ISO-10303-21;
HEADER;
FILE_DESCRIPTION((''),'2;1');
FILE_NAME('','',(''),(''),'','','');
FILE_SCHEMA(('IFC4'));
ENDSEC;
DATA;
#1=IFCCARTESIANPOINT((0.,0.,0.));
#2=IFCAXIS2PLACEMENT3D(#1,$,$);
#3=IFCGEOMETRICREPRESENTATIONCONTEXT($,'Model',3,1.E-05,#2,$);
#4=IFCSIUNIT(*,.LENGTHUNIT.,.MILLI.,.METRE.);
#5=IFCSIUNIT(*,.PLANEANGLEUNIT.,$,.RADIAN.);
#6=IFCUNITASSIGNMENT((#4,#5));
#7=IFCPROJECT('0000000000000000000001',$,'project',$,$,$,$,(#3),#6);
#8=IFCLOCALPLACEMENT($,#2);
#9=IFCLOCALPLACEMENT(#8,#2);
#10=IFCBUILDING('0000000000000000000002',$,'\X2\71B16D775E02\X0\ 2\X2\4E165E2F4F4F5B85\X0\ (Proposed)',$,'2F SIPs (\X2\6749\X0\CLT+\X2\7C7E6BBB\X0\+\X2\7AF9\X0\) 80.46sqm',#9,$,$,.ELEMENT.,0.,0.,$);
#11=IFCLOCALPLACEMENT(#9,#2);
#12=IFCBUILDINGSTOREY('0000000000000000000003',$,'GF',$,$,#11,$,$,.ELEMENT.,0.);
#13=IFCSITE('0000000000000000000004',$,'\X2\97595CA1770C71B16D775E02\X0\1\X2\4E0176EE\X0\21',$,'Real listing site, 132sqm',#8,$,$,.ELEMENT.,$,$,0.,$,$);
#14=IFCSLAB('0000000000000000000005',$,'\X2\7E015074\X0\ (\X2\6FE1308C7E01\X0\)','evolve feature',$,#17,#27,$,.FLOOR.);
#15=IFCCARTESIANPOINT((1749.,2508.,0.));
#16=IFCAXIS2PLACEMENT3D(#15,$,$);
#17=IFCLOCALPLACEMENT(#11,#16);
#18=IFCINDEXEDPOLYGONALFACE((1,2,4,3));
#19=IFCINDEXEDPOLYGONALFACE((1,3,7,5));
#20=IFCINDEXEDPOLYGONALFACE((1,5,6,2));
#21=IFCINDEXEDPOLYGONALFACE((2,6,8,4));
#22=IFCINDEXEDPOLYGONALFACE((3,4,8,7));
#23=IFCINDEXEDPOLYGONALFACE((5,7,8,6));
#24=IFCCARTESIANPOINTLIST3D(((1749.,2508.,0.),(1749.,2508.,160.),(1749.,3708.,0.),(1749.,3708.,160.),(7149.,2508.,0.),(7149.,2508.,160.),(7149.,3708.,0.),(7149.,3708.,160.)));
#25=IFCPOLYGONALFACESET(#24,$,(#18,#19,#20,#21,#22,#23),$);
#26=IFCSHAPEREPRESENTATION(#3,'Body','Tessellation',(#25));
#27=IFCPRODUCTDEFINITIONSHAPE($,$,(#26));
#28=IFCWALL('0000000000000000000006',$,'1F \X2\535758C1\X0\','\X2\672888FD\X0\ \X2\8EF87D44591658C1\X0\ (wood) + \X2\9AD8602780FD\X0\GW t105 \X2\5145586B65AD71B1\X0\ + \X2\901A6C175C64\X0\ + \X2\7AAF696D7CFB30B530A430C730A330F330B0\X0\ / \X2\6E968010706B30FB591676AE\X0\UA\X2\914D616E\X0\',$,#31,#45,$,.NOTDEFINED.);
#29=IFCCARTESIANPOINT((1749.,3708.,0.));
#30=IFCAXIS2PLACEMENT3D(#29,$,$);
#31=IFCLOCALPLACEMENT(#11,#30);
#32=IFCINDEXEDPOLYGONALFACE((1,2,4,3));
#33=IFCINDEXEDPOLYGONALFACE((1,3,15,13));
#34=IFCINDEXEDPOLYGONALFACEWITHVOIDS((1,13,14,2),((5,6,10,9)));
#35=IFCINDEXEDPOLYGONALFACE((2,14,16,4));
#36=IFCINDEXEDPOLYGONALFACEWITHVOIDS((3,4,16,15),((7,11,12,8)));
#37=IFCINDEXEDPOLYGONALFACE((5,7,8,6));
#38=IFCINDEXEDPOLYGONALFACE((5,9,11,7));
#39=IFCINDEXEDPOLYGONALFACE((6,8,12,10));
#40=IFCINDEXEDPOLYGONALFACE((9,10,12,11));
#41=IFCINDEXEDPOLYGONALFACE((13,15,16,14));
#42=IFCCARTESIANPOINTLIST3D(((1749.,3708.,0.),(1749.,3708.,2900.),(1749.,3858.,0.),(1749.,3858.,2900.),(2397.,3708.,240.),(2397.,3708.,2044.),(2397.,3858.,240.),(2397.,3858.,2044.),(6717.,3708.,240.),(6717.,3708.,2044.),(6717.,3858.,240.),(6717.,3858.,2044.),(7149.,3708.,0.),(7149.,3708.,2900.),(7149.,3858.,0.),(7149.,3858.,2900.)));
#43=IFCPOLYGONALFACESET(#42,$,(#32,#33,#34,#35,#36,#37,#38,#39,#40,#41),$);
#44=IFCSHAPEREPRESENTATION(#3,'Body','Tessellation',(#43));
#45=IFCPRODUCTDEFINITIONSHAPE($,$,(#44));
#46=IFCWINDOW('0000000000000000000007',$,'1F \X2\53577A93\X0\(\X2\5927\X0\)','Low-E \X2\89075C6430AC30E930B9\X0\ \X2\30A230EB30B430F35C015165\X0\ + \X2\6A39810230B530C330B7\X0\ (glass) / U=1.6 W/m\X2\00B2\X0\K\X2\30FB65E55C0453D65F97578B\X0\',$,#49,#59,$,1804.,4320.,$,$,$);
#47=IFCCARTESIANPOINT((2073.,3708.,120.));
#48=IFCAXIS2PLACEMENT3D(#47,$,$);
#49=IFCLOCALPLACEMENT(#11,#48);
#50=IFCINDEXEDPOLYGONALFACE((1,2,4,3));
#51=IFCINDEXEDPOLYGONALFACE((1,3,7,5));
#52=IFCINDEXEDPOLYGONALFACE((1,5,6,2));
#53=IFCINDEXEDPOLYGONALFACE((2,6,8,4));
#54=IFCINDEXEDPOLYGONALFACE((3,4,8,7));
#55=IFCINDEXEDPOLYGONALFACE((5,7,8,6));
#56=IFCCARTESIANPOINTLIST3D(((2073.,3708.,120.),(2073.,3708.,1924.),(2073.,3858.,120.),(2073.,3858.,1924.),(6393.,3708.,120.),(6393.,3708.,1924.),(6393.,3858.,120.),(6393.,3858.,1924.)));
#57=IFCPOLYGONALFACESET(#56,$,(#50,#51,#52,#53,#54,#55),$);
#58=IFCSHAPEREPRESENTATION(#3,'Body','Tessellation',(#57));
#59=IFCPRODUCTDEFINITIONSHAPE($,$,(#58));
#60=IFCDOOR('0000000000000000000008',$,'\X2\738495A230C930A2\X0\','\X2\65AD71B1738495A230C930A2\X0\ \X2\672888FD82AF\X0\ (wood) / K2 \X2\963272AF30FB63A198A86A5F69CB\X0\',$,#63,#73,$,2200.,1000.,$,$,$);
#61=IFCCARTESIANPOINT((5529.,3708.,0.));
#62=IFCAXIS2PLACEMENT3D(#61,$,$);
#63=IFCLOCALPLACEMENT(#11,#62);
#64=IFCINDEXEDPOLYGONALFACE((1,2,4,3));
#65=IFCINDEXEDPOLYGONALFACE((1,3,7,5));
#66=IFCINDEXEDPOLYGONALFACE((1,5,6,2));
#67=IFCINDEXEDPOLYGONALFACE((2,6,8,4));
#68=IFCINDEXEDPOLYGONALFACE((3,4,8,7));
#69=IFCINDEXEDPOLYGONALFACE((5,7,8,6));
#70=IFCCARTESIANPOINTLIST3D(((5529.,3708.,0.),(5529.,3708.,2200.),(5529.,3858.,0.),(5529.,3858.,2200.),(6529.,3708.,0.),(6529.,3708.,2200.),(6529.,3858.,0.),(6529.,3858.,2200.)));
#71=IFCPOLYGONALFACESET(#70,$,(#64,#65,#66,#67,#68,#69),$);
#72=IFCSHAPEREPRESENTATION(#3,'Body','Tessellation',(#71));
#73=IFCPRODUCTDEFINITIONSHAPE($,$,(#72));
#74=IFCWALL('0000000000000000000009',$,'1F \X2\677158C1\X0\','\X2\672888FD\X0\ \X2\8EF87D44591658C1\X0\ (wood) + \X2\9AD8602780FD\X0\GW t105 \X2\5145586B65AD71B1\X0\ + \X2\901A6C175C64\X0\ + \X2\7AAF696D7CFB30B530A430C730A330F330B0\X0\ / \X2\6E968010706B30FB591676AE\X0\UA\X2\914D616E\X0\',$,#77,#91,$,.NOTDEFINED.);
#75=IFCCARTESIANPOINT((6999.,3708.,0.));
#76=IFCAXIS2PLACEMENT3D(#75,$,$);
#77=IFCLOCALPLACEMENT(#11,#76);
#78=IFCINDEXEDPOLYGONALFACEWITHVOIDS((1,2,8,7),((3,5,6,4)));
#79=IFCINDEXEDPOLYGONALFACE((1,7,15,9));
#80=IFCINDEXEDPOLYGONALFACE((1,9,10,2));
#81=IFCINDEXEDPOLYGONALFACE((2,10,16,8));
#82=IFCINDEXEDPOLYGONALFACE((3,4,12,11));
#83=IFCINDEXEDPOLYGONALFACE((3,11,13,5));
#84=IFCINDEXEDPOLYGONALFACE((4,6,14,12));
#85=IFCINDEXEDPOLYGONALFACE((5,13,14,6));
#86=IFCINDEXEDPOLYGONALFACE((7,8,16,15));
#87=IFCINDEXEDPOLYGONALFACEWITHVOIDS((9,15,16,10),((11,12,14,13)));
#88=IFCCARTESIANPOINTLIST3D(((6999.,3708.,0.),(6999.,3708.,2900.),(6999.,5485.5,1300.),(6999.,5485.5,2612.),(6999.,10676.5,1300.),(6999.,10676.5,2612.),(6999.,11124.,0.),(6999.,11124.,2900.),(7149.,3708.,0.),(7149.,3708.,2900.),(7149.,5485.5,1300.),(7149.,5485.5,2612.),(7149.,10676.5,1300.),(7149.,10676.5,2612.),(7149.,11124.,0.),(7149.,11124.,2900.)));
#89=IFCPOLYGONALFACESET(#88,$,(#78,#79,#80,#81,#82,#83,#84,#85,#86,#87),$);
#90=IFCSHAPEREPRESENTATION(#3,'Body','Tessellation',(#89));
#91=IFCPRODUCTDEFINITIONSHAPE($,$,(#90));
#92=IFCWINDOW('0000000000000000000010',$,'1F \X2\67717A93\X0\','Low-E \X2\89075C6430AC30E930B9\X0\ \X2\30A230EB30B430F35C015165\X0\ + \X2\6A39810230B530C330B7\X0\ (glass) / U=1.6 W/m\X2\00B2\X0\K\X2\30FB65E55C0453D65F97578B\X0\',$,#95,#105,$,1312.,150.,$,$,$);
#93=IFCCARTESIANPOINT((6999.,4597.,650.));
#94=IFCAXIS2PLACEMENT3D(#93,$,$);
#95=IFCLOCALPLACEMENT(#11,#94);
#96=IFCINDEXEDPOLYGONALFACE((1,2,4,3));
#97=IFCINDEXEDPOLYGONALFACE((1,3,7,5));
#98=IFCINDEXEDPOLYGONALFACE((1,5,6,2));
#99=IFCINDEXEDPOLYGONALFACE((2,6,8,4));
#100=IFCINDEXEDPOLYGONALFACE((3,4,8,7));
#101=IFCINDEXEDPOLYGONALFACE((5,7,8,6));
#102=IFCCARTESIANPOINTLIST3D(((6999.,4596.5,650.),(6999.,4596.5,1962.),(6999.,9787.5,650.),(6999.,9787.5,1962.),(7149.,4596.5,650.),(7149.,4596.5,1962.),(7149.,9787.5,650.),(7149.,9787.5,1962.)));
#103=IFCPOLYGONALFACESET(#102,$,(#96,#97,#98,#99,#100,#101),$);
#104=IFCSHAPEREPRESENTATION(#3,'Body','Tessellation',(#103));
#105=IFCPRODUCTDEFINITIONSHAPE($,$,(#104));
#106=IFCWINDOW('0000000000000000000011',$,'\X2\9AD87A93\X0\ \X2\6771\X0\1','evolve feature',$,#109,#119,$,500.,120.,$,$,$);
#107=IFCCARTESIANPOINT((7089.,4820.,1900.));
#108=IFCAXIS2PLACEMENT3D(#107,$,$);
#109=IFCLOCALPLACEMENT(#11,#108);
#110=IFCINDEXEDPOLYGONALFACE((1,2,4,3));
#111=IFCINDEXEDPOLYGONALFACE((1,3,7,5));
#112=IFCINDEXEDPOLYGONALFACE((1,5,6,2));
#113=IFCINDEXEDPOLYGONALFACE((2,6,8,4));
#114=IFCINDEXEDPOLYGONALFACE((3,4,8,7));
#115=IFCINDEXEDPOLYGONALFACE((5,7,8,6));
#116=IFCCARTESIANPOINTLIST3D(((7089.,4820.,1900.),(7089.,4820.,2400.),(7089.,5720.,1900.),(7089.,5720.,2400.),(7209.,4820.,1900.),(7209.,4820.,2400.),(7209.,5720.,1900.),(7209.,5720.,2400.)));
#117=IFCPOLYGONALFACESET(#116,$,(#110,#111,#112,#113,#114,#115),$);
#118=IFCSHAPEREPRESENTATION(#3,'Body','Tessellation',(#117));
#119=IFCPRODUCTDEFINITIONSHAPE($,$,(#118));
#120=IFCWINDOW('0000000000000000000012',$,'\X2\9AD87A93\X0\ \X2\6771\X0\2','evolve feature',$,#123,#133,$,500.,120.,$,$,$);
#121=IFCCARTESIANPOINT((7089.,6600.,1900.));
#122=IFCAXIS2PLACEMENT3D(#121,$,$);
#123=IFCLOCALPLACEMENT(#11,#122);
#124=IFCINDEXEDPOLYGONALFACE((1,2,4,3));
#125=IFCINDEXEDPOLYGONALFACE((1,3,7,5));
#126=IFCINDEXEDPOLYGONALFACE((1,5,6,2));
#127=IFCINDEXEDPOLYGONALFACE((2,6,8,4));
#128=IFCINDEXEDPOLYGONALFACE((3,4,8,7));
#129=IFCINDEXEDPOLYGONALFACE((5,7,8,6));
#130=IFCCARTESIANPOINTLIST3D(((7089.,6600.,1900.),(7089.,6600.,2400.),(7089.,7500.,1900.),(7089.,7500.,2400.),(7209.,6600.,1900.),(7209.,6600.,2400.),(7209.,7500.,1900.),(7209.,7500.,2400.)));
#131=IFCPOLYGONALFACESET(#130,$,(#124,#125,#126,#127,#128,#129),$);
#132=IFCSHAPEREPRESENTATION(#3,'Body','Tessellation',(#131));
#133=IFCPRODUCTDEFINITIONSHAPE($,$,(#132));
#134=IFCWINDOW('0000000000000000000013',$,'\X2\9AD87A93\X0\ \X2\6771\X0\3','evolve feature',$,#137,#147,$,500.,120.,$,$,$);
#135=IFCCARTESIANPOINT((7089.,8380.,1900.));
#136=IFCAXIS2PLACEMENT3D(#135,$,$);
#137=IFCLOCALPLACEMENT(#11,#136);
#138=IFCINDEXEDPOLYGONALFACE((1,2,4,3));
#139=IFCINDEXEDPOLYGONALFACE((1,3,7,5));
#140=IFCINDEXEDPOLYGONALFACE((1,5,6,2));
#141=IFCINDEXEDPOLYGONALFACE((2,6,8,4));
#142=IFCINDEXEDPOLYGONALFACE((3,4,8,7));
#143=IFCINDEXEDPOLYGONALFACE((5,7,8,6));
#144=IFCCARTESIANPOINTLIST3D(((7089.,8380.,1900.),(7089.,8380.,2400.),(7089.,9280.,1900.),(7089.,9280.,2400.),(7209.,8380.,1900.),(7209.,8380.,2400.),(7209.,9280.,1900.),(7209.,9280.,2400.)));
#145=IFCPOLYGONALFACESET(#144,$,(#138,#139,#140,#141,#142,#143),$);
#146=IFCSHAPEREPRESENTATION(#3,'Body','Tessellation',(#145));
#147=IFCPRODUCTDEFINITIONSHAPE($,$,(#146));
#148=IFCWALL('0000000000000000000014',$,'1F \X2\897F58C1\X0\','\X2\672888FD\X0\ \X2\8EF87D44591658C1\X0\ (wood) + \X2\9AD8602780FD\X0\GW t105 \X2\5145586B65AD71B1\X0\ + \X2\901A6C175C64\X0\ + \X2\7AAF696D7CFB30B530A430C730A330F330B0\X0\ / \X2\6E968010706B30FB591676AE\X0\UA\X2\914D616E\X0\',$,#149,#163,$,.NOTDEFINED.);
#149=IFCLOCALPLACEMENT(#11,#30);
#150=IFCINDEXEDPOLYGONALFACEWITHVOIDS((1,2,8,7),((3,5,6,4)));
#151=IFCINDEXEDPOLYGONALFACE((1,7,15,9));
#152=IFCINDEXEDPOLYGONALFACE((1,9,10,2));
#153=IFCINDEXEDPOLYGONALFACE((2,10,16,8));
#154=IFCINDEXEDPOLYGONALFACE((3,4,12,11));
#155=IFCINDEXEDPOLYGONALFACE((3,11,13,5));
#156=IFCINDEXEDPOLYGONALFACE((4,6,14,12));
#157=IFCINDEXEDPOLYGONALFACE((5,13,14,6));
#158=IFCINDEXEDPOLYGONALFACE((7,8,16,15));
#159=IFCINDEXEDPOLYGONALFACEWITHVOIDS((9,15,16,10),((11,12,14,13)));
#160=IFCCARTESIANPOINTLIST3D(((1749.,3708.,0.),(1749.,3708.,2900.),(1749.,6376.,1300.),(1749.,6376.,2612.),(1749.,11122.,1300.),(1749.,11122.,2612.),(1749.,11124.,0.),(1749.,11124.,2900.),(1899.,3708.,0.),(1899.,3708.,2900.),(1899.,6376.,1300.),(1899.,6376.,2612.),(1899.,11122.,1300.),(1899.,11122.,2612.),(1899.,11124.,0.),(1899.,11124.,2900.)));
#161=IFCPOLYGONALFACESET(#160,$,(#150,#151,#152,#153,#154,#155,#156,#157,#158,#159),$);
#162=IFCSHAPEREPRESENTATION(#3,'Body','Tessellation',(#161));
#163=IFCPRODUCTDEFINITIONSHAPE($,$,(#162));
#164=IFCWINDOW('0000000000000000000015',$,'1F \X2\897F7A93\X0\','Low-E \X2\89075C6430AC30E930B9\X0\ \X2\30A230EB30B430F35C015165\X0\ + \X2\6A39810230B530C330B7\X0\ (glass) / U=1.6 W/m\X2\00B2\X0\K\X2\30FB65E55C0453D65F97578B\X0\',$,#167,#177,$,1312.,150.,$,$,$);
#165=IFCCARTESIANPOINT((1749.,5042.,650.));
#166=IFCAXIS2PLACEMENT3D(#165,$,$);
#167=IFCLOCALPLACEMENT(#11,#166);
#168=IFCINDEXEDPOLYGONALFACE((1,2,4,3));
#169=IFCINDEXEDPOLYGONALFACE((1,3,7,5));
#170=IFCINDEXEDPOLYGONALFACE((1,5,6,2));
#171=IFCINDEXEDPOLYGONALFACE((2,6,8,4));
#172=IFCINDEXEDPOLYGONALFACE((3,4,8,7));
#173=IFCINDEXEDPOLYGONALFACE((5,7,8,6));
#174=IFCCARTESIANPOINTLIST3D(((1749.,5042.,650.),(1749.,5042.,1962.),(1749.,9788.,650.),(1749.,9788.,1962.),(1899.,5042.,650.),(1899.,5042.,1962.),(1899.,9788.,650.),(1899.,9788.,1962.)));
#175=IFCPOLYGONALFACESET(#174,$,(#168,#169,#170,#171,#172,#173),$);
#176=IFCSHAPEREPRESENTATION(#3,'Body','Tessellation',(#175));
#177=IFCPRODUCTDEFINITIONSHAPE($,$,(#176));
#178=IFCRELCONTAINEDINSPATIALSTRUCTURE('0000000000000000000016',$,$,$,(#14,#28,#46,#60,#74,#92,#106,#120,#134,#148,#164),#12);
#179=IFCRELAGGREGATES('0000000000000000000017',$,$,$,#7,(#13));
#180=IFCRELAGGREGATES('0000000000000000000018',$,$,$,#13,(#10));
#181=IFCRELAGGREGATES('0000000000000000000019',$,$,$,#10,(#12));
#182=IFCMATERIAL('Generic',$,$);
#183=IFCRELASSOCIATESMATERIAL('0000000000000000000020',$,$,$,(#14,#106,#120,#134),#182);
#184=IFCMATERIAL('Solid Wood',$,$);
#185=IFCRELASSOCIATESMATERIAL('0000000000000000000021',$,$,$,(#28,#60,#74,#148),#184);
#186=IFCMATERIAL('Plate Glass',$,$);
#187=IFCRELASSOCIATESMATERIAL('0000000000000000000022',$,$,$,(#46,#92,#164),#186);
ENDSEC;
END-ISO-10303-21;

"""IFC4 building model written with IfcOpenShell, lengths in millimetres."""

from ifc_helpers import new_model, si_unit, frame, frame_2d, origin, place, context, project, spatial, rectangle, extrude, material, element, fill, save


model = new_model("IFC4")

# Units and contexts
model_context = context("Model", 3, precision=1e-05, world=origin())
ifc_project = project(units=[si_unit("LENGTHUNIT", "METRE", prefix="MILLI"), si_unit("PLANEANGLEUNIT", "RADIAN")], contexts=[model_context])

# Site, building, storey
site_placement = place(None, origin())
site = spatial("IfcSite", under=ifc_project, at=site_placement, Name="静岡県熱海市1丁目21", ObjectType="Real listing site, 132sqm", CompositionType="ELEMENT", RefElevation=0.0)
building_placement = place(site_placement, origin())
building = spatial("IfcBuilding", under=site, at=building_placement, Name="熱海市 2世帯住宅 (Proposed)", ObjectType="2F SIPs (杉CLT+籾殻+竹) 80.46sqm", CompositionType="ELEMENT", ElevationOfRefHeight=0.0, ElevationOfTerrain=0.0)
storey_placement = place(building_placement, origin())
storey = spatial("IfcBuildingStorey", under=building, at=storey_placement, Name="GF", CompositionType="ELEMENT", Elevation=0.0)

# Slab
ifc_material_1 = material(Name="Solid Wood")
ifc_material_2 = material(Name="Generic")
slab_1_placement = place(storey_placement, frame((1749.0, 2508.0, 0.0)))
element("IfcSlab", 1, at=slab_1_placement, inside=storey, material=ifc_material_2, Name="縁側 (濡れ縁)", Description="evolve feature", PredefinedType="FLOOR", context=model_context, shape_type="SweptSolid", body=[
    extrude(rectangle(XDim=5400.0, YDim=1200.0, at=frame_2d((2700.0, 600.0))), frame((1749.0, 2508.0, 0.0)), (0.0, 0.0, 1.0), 160.0),
])

# Wall, openings, window, door
wall_1_placement = place(storey_placement, frame((1749.0, 3708.0, 0.0)))
wall_1 = element("IfcWall", 2, at=wall_1_placement, inside=storey, material=ifc_material_1, Name="1F 南壁", Description="木製 軸組外壁 (wood) + 高性能GW t105 充填断熱 + 通気層 + 窯業系サイディング / 準耐火・外皮UA配慮", PredefinedType="NOTDEFINED", context=model_context, shape_type="SweptSolid", body=[
    extrude(rectangle(XDim=5400.0, YDim=150.0, at=frame_2d((2700.0, 75.0))), frame((1749.0, 3708.0, 0.0)), (0.0, 0.0, 1.0), 2900.0),
])
opening_1_placement = place(storey_placement, frame((2073.0, 3708.0, 120.0)))
opening_1 = element("IfcOpeningElement", 3, at=opening_1_placement, cuts=wall_1, PredefinedType="NOTDEFINED", context=model_context, shape_type="SweptSolid", body=[
    extrude(rectangle(XDim=4320.0, YDim=150.0, at=frame_2d((2160.0, 75.0))), frame((2073.0, 3708.0, 120.0)), (0.0, 0.0, 1.0), 1804.0),
])
opening_2_placement = place(storey_placement, frame((5529.0, 3708.0, 0.0)))
opening_2 = element("IfcOpeningElement", 4, at=opening_2_placement, cuts=wall_1, PredefinedType="NOTDEFINED", context=model_context, shape_type="SweptSolid", body=[
    extrude(rectangle(XDim=1000.0, YDim=150.0, at=frame_2d((500.0, 75.0))), frame((5529.0, 3708.0, 0.0)), (0.0, 0.0, 1.0), 2200.0),
])
ifc_material_3 = material(Name="Plate Glass")
window_1_placement = place(storey_placement, frame((2073.0, 3708.0, 120.0)))
window_1 = element("IfcWindow", 5, at=window_1_placement, inside=storey, material=ifc_material_3, Name="1F 南窓(大)", Description="Low-E 複層ガラス アルゴン封入 + 樹脂サッシ (glass) / U=1.6 W/m²K・日射取得型", OverallHeight=1804.0, OverallWidth=4320.0, context=model_context, shape_type="SweptSolid", body=[
    extrude(rectangle(XDim=4320.0, YDim=150.0, at=frame_2d((2160.0, 75.0))), frame((2073.0, 3708.0, 120.0)), (0.0, 0.0, 1.0), 1804.0),
])
fill(opening_1, window_1)
door_placement = place(storey_placement, frame((5529.0, 3708.0, 0.0)))
door = element("IfcDoor", 6, at=door_placement, inside=storey, material=ifc_material_1, Name="玄関ドア", Description="断熱玄関ドア 木製芯 (wood) / K2 防犯・採風機構", OverallHeight=2200.0, OverallWidth=1000.0, context=model_context, shape_type="SweptSolid", body=[
    extrude(rectangle(XDim=1000.0, YDim=150.0, at=frame_2d((500.0, 75.0))), frame((5529.0, 3708.0, 0.0)), (0.0, 0.0, 1.0), 2200.0),
])
fill(opening_2, door)

# Wall, openings, windows
wall_2_placement = place(storey_placement, frame((6999.0, 3708.0, 0.0)))
wall_2 = element("IfcWall", 7, at=wall_2_placement, inside=storey, material=ifc_material_1, Name="1F 東壁", Description="木製 軸組外壁 (wood) + 高性能GW t105 充填断熱 + 通気層 + 窯業系サイディング / 準耐火・外皮UA配慮", PredefinedType="NOTDEFINED", context=model_context, shape_type="SweptSolid", body=[
    extrude(rectangle(XDim=150.0, YDim=7416.0, at=frame_2d((75.0, 3708.0))), frame((6999.0, 3708.0, 0.0)), (0.0, 0.0, 1.0), 2900.0),
])
opening_3_placement = place(storey_placement, frame((6999.0, 4597.0, 650.0)))
opening_3 = element("IfcOpeningElement", 8, at=opening_3_placement, cuts=wall_2, PredefinedType="NOTDEFINED", context=model_context, shape_type="SweptSolid", body=[
    extrude(rectangle(XDim=150.0, YDim=5191.0, at=frame_2d((75.0, 2595.0))), frame((6999.0, 4597.0, 650.0)), (0.0, 0.0, 1.0), 1312.0),
])
opening_4_placement = place(storey_placement, frame((7089.0, 4820.0, 1900.0)))
opening_4 = element("IfcOpeningElement", 9, at=opening_4_placement, cuts=wall_2, PredefinedType="NOTDEFINED", context=model_context, shape_type="SweptSolid", body=[
    extrude(rectangle(XDim=120.0, YDim=900.0, at=frame_2d((60.0, 450.0))), frame((7089.0, 4820.0, 1900.0)), (0.0, 0.0, 1.0), 500.0),
])
opening_5_placement = place(storey_placement, frame((7089.0, 6600.0, 1900.0)))
opening_5 = element("IfcOpeningElement", 10, at=opening_5_placement, cuts=wall_2, PredefinedType="NOTDEFINED", context=model_context, shape_type="SweptSolid", body=[
    extrude(rectangle(XDim=120.0, YDim=900.0, at=frame_2d((60.0, 450.0))), frame((7089.0, 6600.0, 1900.0)), (0.0, 0.0, 1.0), 500.0),
])
opening_6_placement = place(storey_placement, frame((7089.0, 8380.0, 1900.0)))
opening_6 = element("IfcOpeningElement", 11, at=opening_6_placement, cuts=wall_2, PredefinedType="NOTDEFINED", context=model_context, shape_type="SweptSolid", body=[
    extrude(rectangle(XDim=120.0, YDim=900.0, at=frame_2d((60.0, 450.0))), frame((7089.0, 8380.0, 1900.0)), (0.0, 0.0, 1.0), 500.0),
])
window_2_placement = place(storey_placement, frame((6999.0, 4597.0, 650.0)))
window_2 = element("IfcWindow", 12, at=window_2_placement, inside=storey, material=ifc_material_3, Name="1F 東窓", Description="Low-E 複層ガラス アルゴン封入 + 樹脂サッシ (glass) / U=1.6 W/m²K・日射取得型", OverallHeight=1312.0, OverallWidth=150.0, context=model_context, shape_type="SweptSolid", body=[
    extrude(rectangle(XDim=150.0, YDim=5191.0, at=frame_2d((75.0, 2595.0))), frame((6999.0, 4597.0, 650.0)), (0.0, 0.0, 1.0), 1312.0),
])
fill(opening_3, window_2)
window_3_placement = place(storey_placement, frame((7089.0, 4820.0, 1900.0)))
window_3 = element("IfcWindow", 13, at=window_3_placement, inside=storey, material=ifc_material_2, Name="高窓 東1", Description="evolve feature", OverallHeight=500.0, OverallWidth=120.0, context=model_context, shape_type="SweptSolid", body=[
    extrude(rectangle(XDim=120.0, YDim=900.0, at=frame_2d((60.0, 450.0))), frame((7089.0, 4820.0, 1900.0)), (0.0, 0.0, 1.0), 500.0),
])
fill(opening_4, window_3)
window_4_placement = place(storey_placement, frame((7089.0, 6600.0, 1900.0)))
window_4 = element("IfcWindow", 14, at=window_4_placement, inside=storey, material=ifc_material_2, Name="高窓 東2", Description="evolve feature", OverallHeight=500.0, OverallWidth=120.0, context=model_context, shape_type="SweptSolid", body=[
    extrude(rectangle(XDim=120.0, YDim=900.0, at=frame_2d((60.0, 450.0))), frame((7089.0, 6600.0, 1900.0)), (0.0, 0.0, 1.0), 500.0),
])
fill(opening_5, window_4)
window_5_placement = place(storey_placement, frame((7089.0, 8380.0, 1900.0)))
window_5 = element("IfcWindow", 15, at=window_5_placement, inside=storey, material=ifc_material_2, Name="高窓 東3", Description="evolve feature", OverallHeight=500.0, OverallWidth=120.0, context=model_context, shape_type="SweptSolid", body=[
    extrude(rectangle(XDim=120.0, YDim=900.0, at=frame_2d((60.0, 450.0))), frame((7089.0, 8380.0, 1900.0)), (0.0, 0.0, 1.0), 500.0),
])
fill(opening_6, window_5)

# Wall, opening, window
wall_3_placement = place(storey_placement, frame((1749.0, 3708.0, 0.0)))
wall_3 = element("IfcWall", 16, at=wall_3_placement, inside=storey, material=ifc_material_1, Name="1F 西壁", Description="木製 軸組外壁 (wood) + 高性能GW t105 充填断熱 + 通気層 + 窯業系サイディング / 準耐火・外皮UA配慮", PredefinedType="NOTDEFINED", context=model_context, shape_type="SweptSolid", body=[
    extrude(rectangle(XDim=150.0, YDim=7416.0, at=frame_2d((75.0, 3708.0))), frame((1749.0, 3708.0, 0.0)), (0.0, 0.0, 1.0), 2900.0),
])
opening_7_placement = place(storey_placement, frame((1749.0, 5042.0, 650.0)))
opening_7 = element("IfcOpeningElement", 17, at=opening_7_placement, cuts=wall_3, PredefinedType="NOTDEFINED", context=model_context, shape_type="SweptSolid", body=[
    extrude(rectangle(XDim=150.0, YDim=4746.0, at=frame_2d((75.0, 2373.0))), frame((1749.0, 5042.0, 650.0)), (0.0, 0.0, 1.0), 1312.0),
])
window_6_placement = place(storey_placement, frame((1749.0, 5042.0, 650.0)))
window_6 = element("IfcWindow", 18, at=window_6_placement, inside=storey, material=ifc_material_3, Name="1F 西窓", Description="Low-E 複層ガラス アルゴン封入 + 樹脂サッシ (glass) / U=1.6 W/m²K・日射取得型", OverallHeight=1312.0, OverallWidth=150.0, context=model_context, shape_type="SweptSolid", body=[
    extrude(rectangle(XDim=150.0, YDim=4746.0, at=frame_2d((75.0, 2373.0))), frame((1749.0, 5042.0, 650.0)), (0.0, 0.0, 1.0), 1312.0),
])
fill(opening_7, window_6)

save(model, "model.ifc")
